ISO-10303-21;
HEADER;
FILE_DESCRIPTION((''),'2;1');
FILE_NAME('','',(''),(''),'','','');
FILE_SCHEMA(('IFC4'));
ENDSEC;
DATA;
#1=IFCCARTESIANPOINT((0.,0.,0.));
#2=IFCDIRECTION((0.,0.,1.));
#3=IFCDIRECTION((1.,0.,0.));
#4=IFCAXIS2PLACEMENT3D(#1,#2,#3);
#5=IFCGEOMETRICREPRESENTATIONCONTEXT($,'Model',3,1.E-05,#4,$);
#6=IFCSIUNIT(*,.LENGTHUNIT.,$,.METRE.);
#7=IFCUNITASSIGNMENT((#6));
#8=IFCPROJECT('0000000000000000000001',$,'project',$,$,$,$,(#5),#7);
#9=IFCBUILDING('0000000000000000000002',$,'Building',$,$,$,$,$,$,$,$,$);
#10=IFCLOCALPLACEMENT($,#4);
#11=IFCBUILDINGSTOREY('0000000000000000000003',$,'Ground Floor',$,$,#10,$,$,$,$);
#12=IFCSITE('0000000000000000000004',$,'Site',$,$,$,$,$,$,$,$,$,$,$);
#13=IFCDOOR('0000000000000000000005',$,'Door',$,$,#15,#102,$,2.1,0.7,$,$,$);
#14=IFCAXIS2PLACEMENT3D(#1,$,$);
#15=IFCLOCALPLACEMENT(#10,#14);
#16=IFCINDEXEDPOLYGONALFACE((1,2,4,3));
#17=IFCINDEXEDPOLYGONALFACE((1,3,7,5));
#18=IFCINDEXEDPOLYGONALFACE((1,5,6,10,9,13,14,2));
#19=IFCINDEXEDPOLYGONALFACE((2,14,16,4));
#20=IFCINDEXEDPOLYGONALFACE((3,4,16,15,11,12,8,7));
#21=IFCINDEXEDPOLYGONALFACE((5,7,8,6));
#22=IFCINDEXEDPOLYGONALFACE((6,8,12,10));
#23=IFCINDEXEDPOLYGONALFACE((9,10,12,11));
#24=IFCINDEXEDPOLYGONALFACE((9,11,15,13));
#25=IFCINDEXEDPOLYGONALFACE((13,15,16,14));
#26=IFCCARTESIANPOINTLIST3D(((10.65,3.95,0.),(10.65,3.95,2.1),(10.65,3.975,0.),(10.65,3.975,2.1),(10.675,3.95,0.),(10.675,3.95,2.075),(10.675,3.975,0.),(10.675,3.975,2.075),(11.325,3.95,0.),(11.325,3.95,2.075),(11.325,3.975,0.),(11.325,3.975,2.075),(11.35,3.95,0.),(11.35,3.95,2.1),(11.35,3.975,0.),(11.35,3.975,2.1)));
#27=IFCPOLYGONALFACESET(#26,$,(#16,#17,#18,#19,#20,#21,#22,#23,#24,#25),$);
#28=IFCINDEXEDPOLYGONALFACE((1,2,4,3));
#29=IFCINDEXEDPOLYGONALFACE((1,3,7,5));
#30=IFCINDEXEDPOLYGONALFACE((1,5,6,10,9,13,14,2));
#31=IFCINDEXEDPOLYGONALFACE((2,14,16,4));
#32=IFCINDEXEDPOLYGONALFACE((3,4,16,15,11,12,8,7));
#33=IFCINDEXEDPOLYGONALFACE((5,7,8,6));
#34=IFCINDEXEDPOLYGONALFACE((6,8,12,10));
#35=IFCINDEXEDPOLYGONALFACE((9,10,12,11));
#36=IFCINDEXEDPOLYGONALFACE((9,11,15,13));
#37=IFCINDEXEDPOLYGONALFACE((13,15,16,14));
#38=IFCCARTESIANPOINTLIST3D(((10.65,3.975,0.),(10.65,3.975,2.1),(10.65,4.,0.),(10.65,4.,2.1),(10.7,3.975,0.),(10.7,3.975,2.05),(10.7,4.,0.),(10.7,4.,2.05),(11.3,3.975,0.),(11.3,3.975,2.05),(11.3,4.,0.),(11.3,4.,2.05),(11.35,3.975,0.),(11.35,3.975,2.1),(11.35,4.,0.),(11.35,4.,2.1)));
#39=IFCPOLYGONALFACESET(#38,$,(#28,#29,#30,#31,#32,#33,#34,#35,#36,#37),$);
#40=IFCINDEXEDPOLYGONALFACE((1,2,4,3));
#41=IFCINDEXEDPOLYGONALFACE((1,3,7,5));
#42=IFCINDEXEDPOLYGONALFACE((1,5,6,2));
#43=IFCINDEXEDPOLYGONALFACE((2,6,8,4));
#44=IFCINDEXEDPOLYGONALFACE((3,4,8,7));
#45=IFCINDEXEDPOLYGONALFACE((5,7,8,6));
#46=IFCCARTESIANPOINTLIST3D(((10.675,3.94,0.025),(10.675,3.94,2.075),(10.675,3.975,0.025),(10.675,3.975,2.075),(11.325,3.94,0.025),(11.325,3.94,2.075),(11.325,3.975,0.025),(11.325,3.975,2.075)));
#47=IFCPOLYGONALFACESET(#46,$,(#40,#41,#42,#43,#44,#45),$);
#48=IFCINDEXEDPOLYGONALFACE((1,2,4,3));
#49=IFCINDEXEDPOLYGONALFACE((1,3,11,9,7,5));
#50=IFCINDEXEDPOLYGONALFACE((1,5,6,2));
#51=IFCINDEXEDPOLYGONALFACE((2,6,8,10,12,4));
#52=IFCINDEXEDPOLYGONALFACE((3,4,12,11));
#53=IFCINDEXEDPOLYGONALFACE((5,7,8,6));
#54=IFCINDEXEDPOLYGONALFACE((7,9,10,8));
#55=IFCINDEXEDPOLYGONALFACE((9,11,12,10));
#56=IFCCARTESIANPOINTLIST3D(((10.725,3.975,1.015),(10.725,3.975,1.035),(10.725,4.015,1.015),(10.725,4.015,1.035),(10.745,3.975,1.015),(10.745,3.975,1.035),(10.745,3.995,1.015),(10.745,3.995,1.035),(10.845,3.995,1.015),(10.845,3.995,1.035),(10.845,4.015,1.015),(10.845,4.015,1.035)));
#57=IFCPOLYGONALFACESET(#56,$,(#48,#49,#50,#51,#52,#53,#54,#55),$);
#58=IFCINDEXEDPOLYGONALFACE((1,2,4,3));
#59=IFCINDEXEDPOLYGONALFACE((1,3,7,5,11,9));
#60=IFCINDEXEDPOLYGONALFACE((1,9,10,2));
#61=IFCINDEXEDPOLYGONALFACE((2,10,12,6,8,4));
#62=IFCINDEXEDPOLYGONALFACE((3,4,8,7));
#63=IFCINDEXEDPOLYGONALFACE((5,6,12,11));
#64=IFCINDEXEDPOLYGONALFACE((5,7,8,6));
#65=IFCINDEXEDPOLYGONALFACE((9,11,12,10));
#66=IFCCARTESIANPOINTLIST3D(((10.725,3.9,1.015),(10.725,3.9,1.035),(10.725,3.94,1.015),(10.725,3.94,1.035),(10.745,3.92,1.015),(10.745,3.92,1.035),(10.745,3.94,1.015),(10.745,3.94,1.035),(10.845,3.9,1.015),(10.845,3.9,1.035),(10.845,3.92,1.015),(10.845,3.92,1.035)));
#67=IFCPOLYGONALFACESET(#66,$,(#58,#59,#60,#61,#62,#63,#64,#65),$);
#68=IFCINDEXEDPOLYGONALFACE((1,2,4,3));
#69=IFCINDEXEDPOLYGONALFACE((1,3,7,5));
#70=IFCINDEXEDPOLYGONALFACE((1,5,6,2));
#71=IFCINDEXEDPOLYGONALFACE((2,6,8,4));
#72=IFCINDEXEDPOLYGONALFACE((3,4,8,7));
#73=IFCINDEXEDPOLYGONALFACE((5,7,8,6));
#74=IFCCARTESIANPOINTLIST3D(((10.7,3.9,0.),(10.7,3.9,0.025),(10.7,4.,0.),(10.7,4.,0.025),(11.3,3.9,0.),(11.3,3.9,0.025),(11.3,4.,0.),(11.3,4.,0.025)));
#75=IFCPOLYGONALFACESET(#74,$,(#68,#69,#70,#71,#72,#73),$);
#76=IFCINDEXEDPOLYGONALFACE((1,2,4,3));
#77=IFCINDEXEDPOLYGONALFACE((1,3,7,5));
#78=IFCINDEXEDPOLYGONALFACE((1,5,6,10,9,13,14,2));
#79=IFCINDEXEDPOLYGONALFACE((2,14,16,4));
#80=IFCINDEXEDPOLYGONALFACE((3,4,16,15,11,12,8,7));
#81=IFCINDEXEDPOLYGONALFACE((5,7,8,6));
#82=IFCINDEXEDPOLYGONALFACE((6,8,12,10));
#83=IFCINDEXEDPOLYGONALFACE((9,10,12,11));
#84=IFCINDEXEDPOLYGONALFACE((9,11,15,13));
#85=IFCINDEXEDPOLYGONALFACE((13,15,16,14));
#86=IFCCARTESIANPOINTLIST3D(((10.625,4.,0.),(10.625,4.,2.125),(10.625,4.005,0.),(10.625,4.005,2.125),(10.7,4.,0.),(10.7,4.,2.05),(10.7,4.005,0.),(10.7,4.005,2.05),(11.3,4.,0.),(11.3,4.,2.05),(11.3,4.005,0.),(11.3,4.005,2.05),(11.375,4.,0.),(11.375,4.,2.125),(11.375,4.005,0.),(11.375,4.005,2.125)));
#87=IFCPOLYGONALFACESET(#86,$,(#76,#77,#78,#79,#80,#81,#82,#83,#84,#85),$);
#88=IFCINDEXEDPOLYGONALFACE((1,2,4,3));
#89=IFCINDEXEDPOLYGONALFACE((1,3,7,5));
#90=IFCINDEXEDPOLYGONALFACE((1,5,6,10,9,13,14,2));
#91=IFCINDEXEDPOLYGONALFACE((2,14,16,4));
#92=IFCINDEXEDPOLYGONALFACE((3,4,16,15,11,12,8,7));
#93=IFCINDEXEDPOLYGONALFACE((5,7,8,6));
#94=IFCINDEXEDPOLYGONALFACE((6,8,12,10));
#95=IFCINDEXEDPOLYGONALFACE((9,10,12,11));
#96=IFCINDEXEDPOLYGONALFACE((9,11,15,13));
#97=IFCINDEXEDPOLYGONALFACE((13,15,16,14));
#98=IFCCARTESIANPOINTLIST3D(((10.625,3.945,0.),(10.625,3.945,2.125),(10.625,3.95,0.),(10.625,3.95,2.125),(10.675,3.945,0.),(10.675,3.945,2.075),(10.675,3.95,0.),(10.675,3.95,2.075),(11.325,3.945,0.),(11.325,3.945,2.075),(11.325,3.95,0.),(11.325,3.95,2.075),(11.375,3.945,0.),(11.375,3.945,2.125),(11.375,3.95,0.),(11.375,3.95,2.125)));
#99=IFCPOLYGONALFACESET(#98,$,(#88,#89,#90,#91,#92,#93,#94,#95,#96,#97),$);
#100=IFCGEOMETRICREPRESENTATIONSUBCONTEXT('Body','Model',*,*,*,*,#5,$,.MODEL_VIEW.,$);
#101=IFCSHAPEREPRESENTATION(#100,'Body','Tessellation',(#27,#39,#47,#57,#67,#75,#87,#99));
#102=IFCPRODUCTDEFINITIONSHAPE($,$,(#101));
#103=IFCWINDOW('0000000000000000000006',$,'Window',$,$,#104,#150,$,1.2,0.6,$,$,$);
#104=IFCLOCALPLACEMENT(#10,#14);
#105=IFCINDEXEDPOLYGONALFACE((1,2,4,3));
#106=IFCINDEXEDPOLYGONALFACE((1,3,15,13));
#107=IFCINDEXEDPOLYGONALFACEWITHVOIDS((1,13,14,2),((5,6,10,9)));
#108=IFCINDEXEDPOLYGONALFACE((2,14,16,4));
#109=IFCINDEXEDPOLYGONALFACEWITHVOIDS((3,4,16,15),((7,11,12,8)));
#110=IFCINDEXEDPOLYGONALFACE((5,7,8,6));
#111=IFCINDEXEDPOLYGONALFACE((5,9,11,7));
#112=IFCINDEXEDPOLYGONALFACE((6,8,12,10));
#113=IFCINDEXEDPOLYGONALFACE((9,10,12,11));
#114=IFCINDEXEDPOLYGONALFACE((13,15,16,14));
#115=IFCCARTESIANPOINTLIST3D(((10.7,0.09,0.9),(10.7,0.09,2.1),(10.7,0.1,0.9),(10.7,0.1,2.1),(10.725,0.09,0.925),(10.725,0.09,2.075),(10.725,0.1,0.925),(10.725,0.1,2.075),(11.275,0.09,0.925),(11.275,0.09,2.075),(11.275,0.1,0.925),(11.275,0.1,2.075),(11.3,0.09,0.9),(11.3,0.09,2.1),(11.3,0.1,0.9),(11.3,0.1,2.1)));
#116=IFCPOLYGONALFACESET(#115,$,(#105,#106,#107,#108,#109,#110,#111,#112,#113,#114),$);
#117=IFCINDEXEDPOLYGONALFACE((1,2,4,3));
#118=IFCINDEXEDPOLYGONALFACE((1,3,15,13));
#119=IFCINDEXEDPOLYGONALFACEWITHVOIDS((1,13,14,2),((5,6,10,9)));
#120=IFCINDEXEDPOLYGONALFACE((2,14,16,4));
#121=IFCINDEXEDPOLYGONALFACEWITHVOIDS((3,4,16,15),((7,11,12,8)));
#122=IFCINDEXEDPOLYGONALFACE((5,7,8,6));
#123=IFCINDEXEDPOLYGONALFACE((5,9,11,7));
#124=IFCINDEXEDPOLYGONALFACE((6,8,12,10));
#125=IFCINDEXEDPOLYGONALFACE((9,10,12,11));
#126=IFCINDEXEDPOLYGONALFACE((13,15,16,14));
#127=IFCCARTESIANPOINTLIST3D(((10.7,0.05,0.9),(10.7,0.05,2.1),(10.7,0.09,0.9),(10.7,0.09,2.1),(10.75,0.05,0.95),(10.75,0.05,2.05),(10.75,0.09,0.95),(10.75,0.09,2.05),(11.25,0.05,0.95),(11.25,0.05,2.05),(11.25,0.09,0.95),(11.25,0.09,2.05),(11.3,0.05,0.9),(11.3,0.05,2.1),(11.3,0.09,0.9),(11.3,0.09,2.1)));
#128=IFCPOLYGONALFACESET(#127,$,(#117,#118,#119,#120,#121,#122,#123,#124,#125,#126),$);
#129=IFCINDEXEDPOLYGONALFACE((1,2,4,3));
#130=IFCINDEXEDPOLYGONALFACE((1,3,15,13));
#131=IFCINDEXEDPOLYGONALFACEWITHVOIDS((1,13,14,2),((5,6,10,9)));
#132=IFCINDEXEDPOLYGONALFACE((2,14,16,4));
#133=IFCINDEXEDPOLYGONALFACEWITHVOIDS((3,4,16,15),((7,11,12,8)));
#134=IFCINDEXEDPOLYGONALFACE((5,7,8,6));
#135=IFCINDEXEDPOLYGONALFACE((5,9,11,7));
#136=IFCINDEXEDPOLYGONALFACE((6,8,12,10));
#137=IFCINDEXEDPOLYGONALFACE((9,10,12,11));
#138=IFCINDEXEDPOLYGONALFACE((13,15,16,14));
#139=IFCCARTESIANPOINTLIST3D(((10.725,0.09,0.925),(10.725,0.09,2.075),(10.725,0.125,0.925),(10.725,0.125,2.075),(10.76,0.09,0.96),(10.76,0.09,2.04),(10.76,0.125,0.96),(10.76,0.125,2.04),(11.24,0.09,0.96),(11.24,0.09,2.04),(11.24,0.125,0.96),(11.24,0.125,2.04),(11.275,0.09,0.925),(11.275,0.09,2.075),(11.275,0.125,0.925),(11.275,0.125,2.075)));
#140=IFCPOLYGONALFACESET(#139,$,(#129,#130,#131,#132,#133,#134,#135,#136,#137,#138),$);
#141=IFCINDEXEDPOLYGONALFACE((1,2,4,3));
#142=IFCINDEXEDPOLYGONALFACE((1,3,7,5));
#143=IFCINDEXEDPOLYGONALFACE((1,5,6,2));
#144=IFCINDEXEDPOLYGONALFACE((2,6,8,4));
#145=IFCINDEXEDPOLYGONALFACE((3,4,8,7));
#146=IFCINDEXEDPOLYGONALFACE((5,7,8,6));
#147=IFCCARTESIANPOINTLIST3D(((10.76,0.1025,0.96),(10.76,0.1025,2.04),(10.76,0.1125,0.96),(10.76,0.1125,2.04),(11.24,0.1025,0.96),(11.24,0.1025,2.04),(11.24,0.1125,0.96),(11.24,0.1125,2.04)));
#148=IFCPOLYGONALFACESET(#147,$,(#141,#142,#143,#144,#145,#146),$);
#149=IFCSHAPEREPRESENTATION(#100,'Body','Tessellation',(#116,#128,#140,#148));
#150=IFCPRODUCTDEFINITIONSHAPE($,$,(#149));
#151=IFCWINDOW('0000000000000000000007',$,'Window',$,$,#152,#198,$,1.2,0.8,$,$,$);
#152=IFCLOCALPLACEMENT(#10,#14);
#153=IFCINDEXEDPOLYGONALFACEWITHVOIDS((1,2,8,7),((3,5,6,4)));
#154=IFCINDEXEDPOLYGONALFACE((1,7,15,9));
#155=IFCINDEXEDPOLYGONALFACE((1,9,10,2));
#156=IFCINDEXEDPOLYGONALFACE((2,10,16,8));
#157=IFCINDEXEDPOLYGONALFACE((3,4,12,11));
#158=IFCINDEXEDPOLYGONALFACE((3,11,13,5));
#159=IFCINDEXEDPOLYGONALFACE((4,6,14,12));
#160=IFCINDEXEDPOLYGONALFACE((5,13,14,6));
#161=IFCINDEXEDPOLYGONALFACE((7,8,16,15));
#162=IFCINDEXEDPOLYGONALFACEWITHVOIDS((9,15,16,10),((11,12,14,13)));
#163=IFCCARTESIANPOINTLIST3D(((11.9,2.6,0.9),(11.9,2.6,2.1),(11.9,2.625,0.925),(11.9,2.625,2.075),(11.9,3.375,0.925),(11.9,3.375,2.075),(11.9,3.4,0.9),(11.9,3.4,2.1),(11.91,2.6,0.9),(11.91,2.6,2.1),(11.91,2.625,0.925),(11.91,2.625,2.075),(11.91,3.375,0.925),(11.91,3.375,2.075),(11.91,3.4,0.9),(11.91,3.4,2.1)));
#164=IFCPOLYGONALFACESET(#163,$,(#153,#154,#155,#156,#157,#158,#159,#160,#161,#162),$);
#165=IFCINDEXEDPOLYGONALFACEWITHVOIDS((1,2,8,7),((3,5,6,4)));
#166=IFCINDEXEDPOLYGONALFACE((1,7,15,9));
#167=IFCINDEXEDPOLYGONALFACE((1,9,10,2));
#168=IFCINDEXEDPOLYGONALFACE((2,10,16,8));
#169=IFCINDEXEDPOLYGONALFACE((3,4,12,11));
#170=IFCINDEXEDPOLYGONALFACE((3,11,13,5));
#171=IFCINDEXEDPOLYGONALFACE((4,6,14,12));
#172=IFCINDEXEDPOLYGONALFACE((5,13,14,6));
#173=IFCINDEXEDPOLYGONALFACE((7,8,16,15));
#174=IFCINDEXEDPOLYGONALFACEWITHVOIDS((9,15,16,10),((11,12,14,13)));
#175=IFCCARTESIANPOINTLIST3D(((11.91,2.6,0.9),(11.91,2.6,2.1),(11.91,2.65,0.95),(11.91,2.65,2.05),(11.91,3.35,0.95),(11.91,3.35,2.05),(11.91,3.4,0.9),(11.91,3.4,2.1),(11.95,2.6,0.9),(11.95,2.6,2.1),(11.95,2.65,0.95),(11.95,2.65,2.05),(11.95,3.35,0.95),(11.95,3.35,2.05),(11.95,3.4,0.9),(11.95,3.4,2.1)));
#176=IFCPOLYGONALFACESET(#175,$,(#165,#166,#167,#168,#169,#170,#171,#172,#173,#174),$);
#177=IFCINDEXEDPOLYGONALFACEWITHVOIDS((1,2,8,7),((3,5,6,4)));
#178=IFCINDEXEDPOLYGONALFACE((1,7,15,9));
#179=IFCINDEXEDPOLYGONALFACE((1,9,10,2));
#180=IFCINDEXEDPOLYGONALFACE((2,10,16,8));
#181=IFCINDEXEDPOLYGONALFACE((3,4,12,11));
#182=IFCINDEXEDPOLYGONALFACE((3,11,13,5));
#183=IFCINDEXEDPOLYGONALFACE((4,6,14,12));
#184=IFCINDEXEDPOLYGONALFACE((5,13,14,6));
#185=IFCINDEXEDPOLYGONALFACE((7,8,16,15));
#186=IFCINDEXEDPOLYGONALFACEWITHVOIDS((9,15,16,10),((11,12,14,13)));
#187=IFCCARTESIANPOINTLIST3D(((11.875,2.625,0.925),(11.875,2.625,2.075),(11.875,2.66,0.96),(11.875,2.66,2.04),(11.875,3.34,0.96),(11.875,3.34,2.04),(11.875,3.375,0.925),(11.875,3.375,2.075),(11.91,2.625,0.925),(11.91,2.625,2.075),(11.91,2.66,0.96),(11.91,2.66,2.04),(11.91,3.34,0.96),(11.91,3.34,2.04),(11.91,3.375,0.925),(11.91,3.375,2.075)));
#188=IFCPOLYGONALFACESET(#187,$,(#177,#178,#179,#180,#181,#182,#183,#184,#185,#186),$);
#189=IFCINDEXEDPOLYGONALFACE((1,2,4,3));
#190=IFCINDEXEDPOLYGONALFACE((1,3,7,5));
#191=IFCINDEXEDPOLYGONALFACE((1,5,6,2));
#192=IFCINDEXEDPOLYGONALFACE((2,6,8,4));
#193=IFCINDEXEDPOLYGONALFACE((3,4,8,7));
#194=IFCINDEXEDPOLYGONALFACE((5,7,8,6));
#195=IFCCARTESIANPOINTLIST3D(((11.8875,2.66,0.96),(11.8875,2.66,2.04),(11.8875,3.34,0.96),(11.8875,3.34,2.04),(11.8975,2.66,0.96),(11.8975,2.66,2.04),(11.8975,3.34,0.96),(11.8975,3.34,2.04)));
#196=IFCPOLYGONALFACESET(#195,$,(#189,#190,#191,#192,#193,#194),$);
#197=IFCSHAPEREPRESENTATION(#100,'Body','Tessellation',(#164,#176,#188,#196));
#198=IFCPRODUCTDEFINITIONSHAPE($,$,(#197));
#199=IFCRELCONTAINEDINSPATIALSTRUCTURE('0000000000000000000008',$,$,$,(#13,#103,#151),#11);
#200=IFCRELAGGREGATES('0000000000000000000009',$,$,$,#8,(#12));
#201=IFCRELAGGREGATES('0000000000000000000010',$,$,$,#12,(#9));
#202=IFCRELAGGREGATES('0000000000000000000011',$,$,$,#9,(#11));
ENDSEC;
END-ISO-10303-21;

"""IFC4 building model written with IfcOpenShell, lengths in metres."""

from ifc_helpers import new_model, si_unit, frame, origin_with_axes, place, context, subcontext, project, spatial, line, indexed_curve, outline, extrude, element, save


model = new_model("IFC4")

# Units and contexts
model_context = context("Model", 3, precision=1e-05, world=origin_with_axes())
body_context = subcontext(model_context, "Body", "Model", "MODEL_VIEW")
ifc_project = project(units=[si_unit("LENGTHUNIT", "METRE")], contexts=[model_context])

# Site, building, storey
site = spatial("IfcSite", under=ifc_project, Name="Site")
building = spatial("IfcBuilding", under=site, Name="Building")
storey_placement = place(None, origin_with_axes())
storey = spatial("IfcBuildingStorey", under=building, at=storey_placement, Name="Ground Floor")

# Door
door_1_placement = place(storey_placement, frame((11.35, 4.0, 0.0), z_axis=(0.0, 0.0, 1.0), x_axis=(-1.0, 0.0, 0.0)))
element("IfcDoor", 1, at=door_1_placement, inside=storey, Name="Door", OverallHeight=2.1, OverallWidth=0.7, context=body_context, shape_type="SweptSolid", body=[
    extrude(outline(indexed_curve([(0.0, 0.0), (0.0, 2.1), (0.7, 2.1), (0.7, 0.0), (0.675, 0.0), (0.675, 2.075), (0.025, 2.075), (0.025, 0.0)], segments=[line(1, 2, 3, 4, 5, 6, 7, 8, 1)])), frame((0.0, 0.025, 0.0), z_axis=(0.0, -1.0, 0.0), x_axis=(1.0, 0.0, 0.0)), (0.0, 0.0, -1.0), 0.025),
    extrude(outline(indexed_curve([(0.0, 0.0), (0.0, 2.1), (0.7, 2.1), (0.7, 0.0), (0.65, 0.0), (0.65, 2.05), (0.05, 2.05), (0.05, 0.0)], segments=[line(1, 2, 3, 4, 5, 6, 7, 8, 1)])), frame((0.0, 0.0, 0.0), z_axis=(0.0, -1.0, 0.0), x_axis=(1.0, 0.0, 0.0)), (0.0, 0.0, -1.0), 0.025),
    extrude(outline(indexed_curve([(0.0, 0.0), (0.65, 0.0), (0.65, 0.035), (0.0, 0.035)], segments=[line(1, 2, 3, 4, 1)])), frame((0.025, 0.025, 0.025), z_axis=(0.0, 0.0, 1.0), x_axis=(1.0, 0.0, 0.0)), (0.0, 0.0, 1.0), 2.05),
    extrude(outline(indexed_curve([(0.0, 0.0), (0.0, -0.04), (-0.12, -0.04), (-0.12, -0.02), (-0.02, -0.02), (-0.02, 0.0)], segments=[line(1, 2, 3, 4, 5, 6, 1)])), frame((0.625, 0.025, 1.015), z_axis=(0.0, 0.0, 1.0), x_axis=(1.0, 0.0, 0.0)), (0.0, 0.0, 1.0), 0.02),
    extrude(outline(indexed_curve([(0.0, 0.0), (0.0, 0.04), (-0.12, 0.04), (-0.12, 0.02), (-0.02, 0.02), (-0.02, 0.0)], segments=[line(1, 2, 3, 4, 5, 6, 1)])), frame((0.625, 0.06, 1.015), z_axis=(0.0, 0.0, 1.0), x_axis=(1.0, 0.0, 0.0)), (0.0, 0.0, 1.0), 0.02),
    extrude(outline(indexed_curve([(0.0, 0.0), (0.6, 0.0), (0.6, 0.1), (0.0, 0.1)], segments=[line(1, 2, 3, 4, 1)])), frame((0.05, 0.0, 0.0), z_axis=(0.0, 0.0, 1.0), x_axis=(1.0, 0.0, 0.0)), (0.0, 0.0, 1.0), 0.025),
    extrude(outline(indexed_curve([(0.0, 0.0), (0.0, 2.125), (0.75, 2.125), (0.75, 0.0), (0.675, 0.0), (0.675, 2.05), (0.075, 2.05), (0.075, 0.0)], segments=[line(1, 2, 3, 4, 5, 6, 7, 8, 1)])), frame((-0.025, -0.005, 0.0), z_axis=(0.0, -1.0, 0.0), x_axis=(1.0, 0.0, 0.0)), (0.0, 0.0, -1.0), 0.005),
    extrude(outline(indexed_curve([(0.0, 0.0), (0.0, 2.125), (0.75, 2.125), (0.75, 0.0), (0.7, 0.0), (0.7, 2.075), (0.05, 2.075), (0.05, 0.0)], segments=[line(1, 2, 3, 4, 5, 6, 7, 8, 1)])), frame((-0.025, 0.05, 0.0), z_axis=(0.0, -1.0, 0.0), x_axis=(1.0, 0.0, 0.0)), (0.0, 0.0, -1.0), 0.005),
])

# Windows
window_1_placement = place(storey_placement, frame((10.7, 0.0, 0.9), z_axis=(0.0, 0.0, 1.0), x_axis=(1.0, 0.0, 0.0)))
element("IfcWindow", 2, at=window_1_placement, inside=storey, Name="Window", OverallHeight=1.2, OverallWidth=0.6, context=body_context, shape_type="SweptSolid", body=[
    extrude(outline(indexed_curve([(0.0, 0.0), (0.6, 0.0), (0.6, 1.2), (0.0, 1.2)], segments=[line(1, 2, 3, 4, 1)]), holes=[indexed_curve([(0.025, 0.025), (0.575, 0.025), (0.575, 1.175), (0.025, 1.175)], segments=[line(1, 2, 3, 4, 1)])]), frame((0.0, 0.09, 0.0), z_axis=(0.0, -1.0, 0.0), x_axis=(1.0, 0.0, 0.0)), (0.0, 0.0, -1.0), 0.01),
    extrude(outline(indexed_curve([(0.0, 0.0), (0.6, 0.0), (0.6, 1.2), (0.0, 1.2)], segments=[line(1, 2, 3, 4, 1)]), holes=[indexed_curve([(0.05, 0.05), (0.55, 0.05), (0.55, 1.15), (0.05, 1.15)], segments=[line(1, 2, 3, 4, 1)])]), frame((0.0, 0.05, 0.0), z_axis=(0.0, -1.0, 0.0), x_axis=(1.0, 0.0, 0.0)), (0.0, 0.0, -1.0), 0.04),
    extrude(outline(indexed_curve([(0.0, 0.0), (0.55, 0.0), (0.55, 1.15), (0.0, 1.15)], segments=[line(1, 2, 3, 4, 1)]), holes=[indexed_curve([(0.035, 0.035), (0.515, 0.035), (0.515, 1.115), (0.035, 1.115)], segments=[line(1, 2, 3, 4, 1)])]), frame((0.025, 0.09, 0.025), z_axis=(0.0, -1.0, 0.0), x_axis=(1.0, 0.0, 0.0)), (0.0, 0.0, -1.0), 0.035),
    extrude(outline(indexed_curve([(0.035, 0.035), (0.515, 0.035), (0.515, 1.115), (0.035, 1.115)], segments=[line(1, 2, 3, 4, 1)])), frame((0.025, 0.1025, 0.025), z_axis=(0.0, -1.0, 0.0), x_axis=(1.0, 0.0, 0.0)), (0.0, 0.0, -1.0), 0.01),
])
window_2_placement = place(storey_placement, frame((12.0, 2.6, 0.9), z_axis=(0.0, 0.0, 1.0), x_axis=(0.0, 1.0, 0.0)))
element("IfcWindow", 3, at=window_2_placement, inside=storey, Name="Window", OverallHeight=1.2, OverallWidth=0.8, context=body_context, shape_type="SweptSolid", body=[
    extrude(outline(indexed_curve([(0.0, 0.0), (0.8, 0.0), (0.8, 1.2), (0.0, 1.2)], segments=[line(1, 2, 3, 4, 1)]), holes=[indexed_curve([(0.025, 0.025), (0.775, 0.025), (0.775, 1.175), (0.025, 1.175)], segments=[line(1, 2, 3, 4, 1)])]), frame((0.0, 0.09, 0.0), z_axis=(0.0, -1.0, 0.0), x_axis=(1.0, 0.0, 0.0)), (0.0, 0.0, -1.0), 0.01),
    extrude(outline(indexed_curve([(0.0, 0.0), (0.8, 0.0), (0.8, 1.2), (0.0, 1.2)], segments=[line(1, 2, 3, 4, 1)]), holes=[indexed_curve([(0.05, 0.05), (0.75, 0.05), (0.75, 1.15), (0.05, 1.15)], segments=[line(1, 2, 3, 4, 1)])]), frame((0.0, 0.05, 0.0), z_axis=(0.0, -1.0, 0.0), x_axis=(1.0, 0.0, 0.0)), (0.0, 0.0, -1.0), 0.04),
    extrude(outline(indexed_curve([(0.0, 0.0), (0.75, 0.0), (0.75, 1.15), (0.0, 1.15)], segments=[line(1, 2, 3, 4, 1)]), holes=[indexed_curve([(0.035, 0.035), (0.715, 0.035), (0.715, 1.115), (0.035, 1.115)], segments=[line(1, 2, 3, 4, 1)])]), frame((0.025, 0.09, 0.025), z_axis=(0.0, -1.0, 0.0), x_axis=(1.0, 0.0, 0.0)), (0.0, 0.0, -1.0), 0.035),
    extrude(outline(indexed_curve([(0.035, 0.035), (0.715, 0.035), (0.715, 1.115), (0.035, 1.115)], segments=[line(1, 2, 3, 4, 1)])), frame((0.025, 0.1025, 0.025), z_axis=(0.0, -1.0, 0.0), x_axis=(1.0, 0.0, 0.0)), (0.0, 0.0, -1.0), 0.01),
])

save(model, "model.ifc")
